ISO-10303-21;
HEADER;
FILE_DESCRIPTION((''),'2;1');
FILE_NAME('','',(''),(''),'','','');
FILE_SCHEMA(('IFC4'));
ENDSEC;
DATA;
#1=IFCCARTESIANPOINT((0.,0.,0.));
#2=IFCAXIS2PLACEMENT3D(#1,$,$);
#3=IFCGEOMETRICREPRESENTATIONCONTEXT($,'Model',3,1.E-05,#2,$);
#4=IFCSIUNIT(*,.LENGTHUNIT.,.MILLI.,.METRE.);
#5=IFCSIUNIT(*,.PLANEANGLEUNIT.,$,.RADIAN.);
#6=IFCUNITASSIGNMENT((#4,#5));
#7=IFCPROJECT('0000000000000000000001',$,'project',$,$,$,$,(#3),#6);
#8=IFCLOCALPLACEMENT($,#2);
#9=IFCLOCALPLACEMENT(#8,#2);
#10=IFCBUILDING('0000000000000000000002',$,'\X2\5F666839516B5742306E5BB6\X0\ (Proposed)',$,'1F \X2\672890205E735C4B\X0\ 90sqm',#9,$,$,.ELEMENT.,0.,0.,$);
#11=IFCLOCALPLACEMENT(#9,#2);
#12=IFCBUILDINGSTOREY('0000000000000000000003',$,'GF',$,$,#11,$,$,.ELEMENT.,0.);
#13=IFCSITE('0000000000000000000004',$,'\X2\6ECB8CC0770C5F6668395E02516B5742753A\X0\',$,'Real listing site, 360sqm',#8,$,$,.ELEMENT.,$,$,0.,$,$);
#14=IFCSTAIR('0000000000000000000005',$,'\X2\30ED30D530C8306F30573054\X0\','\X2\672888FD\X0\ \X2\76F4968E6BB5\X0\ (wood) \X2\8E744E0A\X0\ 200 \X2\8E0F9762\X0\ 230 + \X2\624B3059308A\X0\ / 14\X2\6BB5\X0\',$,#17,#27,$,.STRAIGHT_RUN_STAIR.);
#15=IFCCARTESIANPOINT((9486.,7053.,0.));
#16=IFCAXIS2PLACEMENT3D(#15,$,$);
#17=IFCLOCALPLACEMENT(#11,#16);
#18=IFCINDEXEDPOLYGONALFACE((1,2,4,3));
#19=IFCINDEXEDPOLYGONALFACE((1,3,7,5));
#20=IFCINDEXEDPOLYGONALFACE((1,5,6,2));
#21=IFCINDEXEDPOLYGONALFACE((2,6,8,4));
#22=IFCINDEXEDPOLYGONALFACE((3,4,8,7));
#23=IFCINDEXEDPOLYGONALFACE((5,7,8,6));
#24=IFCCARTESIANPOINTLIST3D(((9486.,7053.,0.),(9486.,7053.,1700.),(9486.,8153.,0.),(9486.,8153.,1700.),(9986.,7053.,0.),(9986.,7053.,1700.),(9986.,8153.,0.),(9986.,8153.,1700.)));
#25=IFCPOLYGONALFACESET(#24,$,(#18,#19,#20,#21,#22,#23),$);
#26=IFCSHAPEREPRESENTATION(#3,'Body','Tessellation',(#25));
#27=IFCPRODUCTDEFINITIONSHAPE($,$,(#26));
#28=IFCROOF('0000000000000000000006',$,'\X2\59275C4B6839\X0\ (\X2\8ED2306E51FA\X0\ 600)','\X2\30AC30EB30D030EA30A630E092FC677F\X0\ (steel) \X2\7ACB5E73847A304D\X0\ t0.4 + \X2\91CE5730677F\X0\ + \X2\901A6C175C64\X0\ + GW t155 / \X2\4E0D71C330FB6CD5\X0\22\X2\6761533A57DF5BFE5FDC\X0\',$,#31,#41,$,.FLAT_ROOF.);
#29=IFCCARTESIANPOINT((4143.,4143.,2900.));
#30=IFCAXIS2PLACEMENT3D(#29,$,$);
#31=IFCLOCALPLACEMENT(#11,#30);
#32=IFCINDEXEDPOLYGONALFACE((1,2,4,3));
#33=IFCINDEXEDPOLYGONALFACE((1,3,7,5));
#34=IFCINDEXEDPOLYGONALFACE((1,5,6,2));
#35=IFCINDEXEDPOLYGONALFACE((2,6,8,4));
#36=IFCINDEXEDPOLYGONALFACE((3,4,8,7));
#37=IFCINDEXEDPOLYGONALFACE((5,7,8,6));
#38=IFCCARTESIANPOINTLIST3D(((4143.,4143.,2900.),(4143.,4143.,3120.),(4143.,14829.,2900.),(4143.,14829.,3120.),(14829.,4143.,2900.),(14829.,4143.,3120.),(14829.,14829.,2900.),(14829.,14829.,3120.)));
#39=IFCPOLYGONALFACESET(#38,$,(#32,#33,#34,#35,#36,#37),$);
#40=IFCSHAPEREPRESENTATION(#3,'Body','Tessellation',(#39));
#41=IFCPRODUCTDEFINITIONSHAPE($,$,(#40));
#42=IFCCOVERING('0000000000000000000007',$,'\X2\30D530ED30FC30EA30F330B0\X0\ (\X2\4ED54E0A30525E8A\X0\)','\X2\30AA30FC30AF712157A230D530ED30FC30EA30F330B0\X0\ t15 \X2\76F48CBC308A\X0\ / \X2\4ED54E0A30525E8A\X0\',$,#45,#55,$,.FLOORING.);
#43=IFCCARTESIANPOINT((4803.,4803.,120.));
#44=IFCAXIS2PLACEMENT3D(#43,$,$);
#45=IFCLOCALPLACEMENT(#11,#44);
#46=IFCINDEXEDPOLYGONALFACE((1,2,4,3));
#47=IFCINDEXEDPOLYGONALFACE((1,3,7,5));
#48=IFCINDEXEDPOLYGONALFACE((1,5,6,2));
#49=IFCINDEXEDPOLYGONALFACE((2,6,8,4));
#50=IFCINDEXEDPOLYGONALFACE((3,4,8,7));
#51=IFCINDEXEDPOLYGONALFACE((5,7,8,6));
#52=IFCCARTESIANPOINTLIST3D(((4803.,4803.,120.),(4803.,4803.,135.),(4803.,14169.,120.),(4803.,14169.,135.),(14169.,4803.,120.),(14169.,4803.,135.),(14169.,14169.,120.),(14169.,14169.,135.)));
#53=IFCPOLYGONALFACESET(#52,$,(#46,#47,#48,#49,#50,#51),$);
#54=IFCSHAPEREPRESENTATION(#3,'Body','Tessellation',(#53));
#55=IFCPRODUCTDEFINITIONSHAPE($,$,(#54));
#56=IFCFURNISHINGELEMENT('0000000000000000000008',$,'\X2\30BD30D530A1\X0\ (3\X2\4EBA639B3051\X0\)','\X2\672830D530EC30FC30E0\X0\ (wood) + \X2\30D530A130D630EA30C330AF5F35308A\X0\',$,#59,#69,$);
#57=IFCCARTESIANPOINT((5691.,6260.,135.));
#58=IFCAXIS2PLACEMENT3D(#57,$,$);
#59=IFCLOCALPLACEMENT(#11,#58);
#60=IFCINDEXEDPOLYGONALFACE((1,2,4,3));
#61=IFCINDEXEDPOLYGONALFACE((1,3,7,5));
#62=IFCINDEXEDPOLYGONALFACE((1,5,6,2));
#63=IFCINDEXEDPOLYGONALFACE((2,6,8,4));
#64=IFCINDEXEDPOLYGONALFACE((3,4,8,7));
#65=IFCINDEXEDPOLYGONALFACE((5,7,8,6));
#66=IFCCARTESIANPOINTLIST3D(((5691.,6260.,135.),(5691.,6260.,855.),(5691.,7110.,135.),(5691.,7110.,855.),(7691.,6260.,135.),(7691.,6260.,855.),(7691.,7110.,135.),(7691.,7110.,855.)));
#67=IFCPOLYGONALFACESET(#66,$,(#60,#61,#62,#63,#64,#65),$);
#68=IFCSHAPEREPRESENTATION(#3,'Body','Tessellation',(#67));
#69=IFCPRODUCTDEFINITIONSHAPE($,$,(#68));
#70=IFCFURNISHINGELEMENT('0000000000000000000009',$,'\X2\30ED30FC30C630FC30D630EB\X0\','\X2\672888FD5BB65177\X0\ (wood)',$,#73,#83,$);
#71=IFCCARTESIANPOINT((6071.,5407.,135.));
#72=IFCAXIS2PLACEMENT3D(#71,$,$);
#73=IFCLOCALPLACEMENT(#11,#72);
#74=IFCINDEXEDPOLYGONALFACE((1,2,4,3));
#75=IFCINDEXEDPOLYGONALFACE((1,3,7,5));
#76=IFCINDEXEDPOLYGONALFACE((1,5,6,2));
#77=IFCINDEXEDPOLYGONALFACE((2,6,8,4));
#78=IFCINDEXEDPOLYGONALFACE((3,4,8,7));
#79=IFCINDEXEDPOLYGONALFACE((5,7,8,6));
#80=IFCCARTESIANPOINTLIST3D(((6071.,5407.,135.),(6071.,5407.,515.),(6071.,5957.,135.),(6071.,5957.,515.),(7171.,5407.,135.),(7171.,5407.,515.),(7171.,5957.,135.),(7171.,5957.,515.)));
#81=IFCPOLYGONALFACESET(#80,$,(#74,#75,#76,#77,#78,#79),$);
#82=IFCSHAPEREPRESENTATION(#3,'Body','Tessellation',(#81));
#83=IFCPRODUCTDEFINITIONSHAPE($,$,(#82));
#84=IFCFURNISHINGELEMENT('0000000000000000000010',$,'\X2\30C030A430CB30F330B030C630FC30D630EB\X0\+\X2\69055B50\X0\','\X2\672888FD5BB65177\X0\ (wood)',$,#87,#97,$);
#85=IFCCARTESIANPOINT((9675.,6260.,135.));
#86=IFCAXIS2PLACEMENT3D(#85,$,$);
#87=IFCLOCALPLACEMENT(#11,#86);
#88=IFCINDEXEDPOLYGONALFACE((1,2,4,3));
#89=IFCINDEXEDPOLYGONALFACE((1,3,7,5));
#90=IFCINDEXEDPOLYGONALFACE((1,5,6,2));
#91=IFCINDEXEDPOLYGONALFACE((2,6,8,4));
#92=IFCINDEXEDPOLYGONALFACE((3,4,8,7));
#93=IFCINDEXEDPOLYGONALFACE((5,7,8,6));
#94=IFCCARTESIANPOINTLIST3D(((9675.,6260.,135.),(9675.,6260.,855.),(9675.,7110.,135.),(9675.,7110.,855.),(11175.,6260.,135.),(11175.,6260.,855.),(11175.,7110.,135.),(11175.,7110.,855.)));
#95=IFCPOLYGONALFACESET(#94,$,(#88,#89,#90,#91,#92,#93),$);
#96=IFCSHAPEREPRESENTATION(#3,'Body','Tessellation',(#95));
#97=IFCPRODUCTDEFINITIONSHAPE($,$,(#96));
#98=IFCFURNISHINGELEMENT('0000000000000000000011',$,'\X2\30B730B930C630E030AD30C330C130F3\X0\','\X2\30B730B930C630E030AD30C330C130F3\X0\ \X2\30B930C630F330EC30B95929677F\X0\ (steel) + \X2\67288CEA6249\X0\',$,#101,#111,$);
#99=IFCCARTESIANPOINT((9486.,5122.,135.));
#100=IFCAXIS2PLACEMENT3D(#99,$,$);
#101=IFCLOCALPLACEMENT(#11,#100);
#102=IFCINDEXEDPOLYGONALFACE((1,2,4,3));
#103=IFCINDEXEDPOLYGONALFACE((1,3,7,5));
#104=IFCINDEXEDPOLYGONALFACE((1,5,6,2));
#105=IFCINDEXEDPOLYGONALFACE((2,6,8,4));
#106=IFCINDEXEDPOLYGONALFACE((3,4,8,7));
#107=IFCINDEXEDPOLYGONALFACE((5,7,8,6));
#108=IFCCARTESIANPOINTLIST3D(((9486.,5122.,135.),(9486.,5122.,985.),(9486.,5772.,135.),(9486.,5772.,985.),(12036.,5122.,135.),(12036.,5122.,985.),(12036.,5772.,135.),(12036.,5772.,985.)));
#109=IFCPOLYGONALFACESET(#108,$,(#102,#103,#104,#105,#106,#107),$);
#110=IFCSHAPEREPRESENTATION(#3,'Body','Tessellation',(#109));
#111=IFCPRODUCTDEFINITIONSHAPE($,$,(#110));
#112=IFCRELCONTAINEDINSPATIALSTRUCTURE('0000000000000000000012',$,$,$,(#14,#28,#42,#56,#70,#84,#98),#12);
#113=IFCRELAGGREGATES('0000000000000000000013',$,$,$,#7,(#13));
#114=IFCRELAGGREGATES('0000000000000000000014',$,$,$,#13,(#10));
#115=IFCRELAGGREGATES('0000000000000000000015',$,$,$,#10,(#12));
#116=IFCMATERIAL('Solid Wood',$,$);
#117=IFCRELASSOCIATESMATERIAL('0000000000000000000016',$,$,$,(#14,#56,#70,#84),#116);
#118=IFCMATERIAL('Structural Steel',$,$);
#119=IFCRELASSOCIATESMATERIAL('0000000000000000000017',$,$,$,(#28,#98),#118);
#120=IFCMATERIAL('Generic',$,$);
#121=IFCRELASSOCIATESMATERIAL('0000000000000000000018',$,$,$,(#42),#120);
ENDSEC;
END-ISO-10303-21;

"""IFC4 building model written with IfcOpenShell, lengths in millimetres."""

from ifc_helpers import new_model, si_unit, frame, frame_2d, origin, place, context, project, spatial, rectangle, extrude, material, element, save


model = new_model("IFC4")

# Units and contexts
model_context = context("Model", 3, precision=1e-05, world=origin())
ifc_project = project(units=[si_unit("LENGTHUNIT", "METRE", prefix="MILLI"), si_unit("PLANEANGLEUNIT", "RADIAN")], contexts=[model_context])

# Site, building, storey
site_placement = place(None, origin())
site = spatial("IfcSite", under=ifc_project, at=site_placement, Name="滋賀県彦根市八坂町", ObjectType="Real listing site, 360sqm", CompositionType="ELEMENT", RefElevation=0.0)
building_placement = place(site_placement, origin())
building = spatial("IfcBuilding", under=site, at=building_placement, Name="彦根八坂の家 (Proposed)", ObjectType="1F 木造平屋 90sqm", CompositionType="ELEMENT", ElevationOfRefHeight=0.0, ElevationOfTerrain=0.0)
storey_placement = place(building_placement, origin())
storey = spatial("IfcBuildingStorey", under=building, at=storey_placement, Name="GF", CompositionType="ELEMENT", Elevation=0.0)

# Shared definitions
ifc_material_1 = material(Name="Solid Wood")

# Stair
stair_placement = place(storey_placement, frame((9486.0, 7053.0, 0.0)))
element("IfcStair", 1, at=stair_placement, inside=storey, material=ifc_material_1, Name="ロフトはしご", Description="木製 直階段 (wood) 蹴上 200 踏面 230 + 手すり / 14段", PredefinedType="STRAIGHT_RUN_STAIR", context=model_context, shape_type="SweptSolid", body=[
    extrude(rectangle(XDim=500.0, YDim=1100.0, at=frame_2d((250.0, 550.0))), frame((9486.0, 7053.0, 0.0)), (0.0, 0.0, 1.0), 1700.0),
])

# Roof
ifc_material_2 = material(Name="Structural Steel")
roof_placement = place(storey_placement, frame((4143.0, 4143.0, 2900.0)))
element("IfcRoof", 2, at=roof_placement, inside=storey, material=ifc_material_2, Name="大屋根 (軒の出 600)", Description="ガルバリウム鋼板 (steel) 立平葺き t0.4 + 野地板 + 通気層 + GW t155 / 不燃・法22条区域対応", PredefinedType="FLAT_ROOF", context=model_context, shape_type="SweptSolid", body=[
    extrude(rectangle(XDim=10686.0, YDim=10686.0, at=frame_2d((5343.0, 5343.0))), frame((4143.0, 4143.0, 2900.0)), (0.0, 0.0, 1.0), 220.0),
])

# Covering
ifc_material_3 = material(Name="Generic")
covering_placement = place(storey_placement, frame((4803.0, 4803.0, 120.0)))
element("IfcCovering", 3, at=covering_placement, inside=storey, material=ifc_material_3, Name="フローリング (仕上げ床)", Description="オーク無垢フローリング t15 直貼り / 仕上げ床", PredefinedType="FLOORING", context=model_context, shape_type="SweptSolid", body=[
    extrude(rectangle(XDim=9366.0, YDim=9366.0, at=frame_2d((4683.0, 4683.0))), frame((4803.0, 4803.0, 120.0)), (0.0, 0.0, 1.0), 15.0),
])

# Furnishing elements
furnishing_1_placement = place(storey_placement, frame((5691.0, 6260.0, 135.0)))
element("IfcFurnishingElement", 4, at=furnishing_1_placement, inside=storey, material=ifc_material_1, Name="ソファ (3人掛け)", Description="木フレーム (wood) + ファブリック張り", context=model_context, shape_type="SweptSolid", body=[
    extrude(rectangle(XDim=2000.0, YDim=850.0, at=frame_2d((1000.0, 425.0))), frame((5691.0, 6260.0, 135.0)), (0.0, 0.0, 1.0), 720.0),
])
furnishing_2_placement = place(storey_placement, frame((6071.0, 5407.0, 135.0)))
element("IfcFurnishingElement", 5, at=furnishing_2_placement, inside=storey, material=ifc_material_1, Name="ローテーブル", Description="木製家具 (wood)", context=model_context, shape_type="SweptSolid", body=[
    extrude(rectangle(XDim=1100.0, YDim=550.0, at=frame_2d((550.0, 275.0))), frame((6071.0, 5407.0, 135.0)), (0.0, 0.0, 1.0), 380.0),
])
furnishing_3_placement = place(storey_placement, frame((9675.0, 6260.0, 135.0)))
element("IfcFurnishingElement", 6, at=furnishing_3_placement, inside=storey, material=ifc_material_1, Name="ダイニングテーブル+椅子", Description="木製家具 (wood)", context=model_context, shape_type="SweptSolid", body=[
    extrude(rectangle(XDim=1500.0, YDim=850.0, at=frame_2d((750.0, 425.0))), frame((9675.0, 6260.0, 135.0)), (0.0, 0.0, 1.0), 720.0),
])
furnishing_4_placement = place(storey_placement, frame((9486.0, 5122.0, 135.0)))
element("IfcFurnishingElement", 7, at=furnishing_4_placement, inside=storey, material=ifc_material_2, Name="システムキッチン", Description="システムキッチン ステンレス天板 (steel) + 木質扉", context=model_context, shape_type="SweptSolid", body=[
    extrude(rectangle(XDim=2550.0, YDim=650.0, at=frame_2d((1275.0, 325.0))), frame((9486.0, 5122.0, 135.0)), (0.0, 0.0, 1.0), 850.0),
])

save(model, "model.ifc")
